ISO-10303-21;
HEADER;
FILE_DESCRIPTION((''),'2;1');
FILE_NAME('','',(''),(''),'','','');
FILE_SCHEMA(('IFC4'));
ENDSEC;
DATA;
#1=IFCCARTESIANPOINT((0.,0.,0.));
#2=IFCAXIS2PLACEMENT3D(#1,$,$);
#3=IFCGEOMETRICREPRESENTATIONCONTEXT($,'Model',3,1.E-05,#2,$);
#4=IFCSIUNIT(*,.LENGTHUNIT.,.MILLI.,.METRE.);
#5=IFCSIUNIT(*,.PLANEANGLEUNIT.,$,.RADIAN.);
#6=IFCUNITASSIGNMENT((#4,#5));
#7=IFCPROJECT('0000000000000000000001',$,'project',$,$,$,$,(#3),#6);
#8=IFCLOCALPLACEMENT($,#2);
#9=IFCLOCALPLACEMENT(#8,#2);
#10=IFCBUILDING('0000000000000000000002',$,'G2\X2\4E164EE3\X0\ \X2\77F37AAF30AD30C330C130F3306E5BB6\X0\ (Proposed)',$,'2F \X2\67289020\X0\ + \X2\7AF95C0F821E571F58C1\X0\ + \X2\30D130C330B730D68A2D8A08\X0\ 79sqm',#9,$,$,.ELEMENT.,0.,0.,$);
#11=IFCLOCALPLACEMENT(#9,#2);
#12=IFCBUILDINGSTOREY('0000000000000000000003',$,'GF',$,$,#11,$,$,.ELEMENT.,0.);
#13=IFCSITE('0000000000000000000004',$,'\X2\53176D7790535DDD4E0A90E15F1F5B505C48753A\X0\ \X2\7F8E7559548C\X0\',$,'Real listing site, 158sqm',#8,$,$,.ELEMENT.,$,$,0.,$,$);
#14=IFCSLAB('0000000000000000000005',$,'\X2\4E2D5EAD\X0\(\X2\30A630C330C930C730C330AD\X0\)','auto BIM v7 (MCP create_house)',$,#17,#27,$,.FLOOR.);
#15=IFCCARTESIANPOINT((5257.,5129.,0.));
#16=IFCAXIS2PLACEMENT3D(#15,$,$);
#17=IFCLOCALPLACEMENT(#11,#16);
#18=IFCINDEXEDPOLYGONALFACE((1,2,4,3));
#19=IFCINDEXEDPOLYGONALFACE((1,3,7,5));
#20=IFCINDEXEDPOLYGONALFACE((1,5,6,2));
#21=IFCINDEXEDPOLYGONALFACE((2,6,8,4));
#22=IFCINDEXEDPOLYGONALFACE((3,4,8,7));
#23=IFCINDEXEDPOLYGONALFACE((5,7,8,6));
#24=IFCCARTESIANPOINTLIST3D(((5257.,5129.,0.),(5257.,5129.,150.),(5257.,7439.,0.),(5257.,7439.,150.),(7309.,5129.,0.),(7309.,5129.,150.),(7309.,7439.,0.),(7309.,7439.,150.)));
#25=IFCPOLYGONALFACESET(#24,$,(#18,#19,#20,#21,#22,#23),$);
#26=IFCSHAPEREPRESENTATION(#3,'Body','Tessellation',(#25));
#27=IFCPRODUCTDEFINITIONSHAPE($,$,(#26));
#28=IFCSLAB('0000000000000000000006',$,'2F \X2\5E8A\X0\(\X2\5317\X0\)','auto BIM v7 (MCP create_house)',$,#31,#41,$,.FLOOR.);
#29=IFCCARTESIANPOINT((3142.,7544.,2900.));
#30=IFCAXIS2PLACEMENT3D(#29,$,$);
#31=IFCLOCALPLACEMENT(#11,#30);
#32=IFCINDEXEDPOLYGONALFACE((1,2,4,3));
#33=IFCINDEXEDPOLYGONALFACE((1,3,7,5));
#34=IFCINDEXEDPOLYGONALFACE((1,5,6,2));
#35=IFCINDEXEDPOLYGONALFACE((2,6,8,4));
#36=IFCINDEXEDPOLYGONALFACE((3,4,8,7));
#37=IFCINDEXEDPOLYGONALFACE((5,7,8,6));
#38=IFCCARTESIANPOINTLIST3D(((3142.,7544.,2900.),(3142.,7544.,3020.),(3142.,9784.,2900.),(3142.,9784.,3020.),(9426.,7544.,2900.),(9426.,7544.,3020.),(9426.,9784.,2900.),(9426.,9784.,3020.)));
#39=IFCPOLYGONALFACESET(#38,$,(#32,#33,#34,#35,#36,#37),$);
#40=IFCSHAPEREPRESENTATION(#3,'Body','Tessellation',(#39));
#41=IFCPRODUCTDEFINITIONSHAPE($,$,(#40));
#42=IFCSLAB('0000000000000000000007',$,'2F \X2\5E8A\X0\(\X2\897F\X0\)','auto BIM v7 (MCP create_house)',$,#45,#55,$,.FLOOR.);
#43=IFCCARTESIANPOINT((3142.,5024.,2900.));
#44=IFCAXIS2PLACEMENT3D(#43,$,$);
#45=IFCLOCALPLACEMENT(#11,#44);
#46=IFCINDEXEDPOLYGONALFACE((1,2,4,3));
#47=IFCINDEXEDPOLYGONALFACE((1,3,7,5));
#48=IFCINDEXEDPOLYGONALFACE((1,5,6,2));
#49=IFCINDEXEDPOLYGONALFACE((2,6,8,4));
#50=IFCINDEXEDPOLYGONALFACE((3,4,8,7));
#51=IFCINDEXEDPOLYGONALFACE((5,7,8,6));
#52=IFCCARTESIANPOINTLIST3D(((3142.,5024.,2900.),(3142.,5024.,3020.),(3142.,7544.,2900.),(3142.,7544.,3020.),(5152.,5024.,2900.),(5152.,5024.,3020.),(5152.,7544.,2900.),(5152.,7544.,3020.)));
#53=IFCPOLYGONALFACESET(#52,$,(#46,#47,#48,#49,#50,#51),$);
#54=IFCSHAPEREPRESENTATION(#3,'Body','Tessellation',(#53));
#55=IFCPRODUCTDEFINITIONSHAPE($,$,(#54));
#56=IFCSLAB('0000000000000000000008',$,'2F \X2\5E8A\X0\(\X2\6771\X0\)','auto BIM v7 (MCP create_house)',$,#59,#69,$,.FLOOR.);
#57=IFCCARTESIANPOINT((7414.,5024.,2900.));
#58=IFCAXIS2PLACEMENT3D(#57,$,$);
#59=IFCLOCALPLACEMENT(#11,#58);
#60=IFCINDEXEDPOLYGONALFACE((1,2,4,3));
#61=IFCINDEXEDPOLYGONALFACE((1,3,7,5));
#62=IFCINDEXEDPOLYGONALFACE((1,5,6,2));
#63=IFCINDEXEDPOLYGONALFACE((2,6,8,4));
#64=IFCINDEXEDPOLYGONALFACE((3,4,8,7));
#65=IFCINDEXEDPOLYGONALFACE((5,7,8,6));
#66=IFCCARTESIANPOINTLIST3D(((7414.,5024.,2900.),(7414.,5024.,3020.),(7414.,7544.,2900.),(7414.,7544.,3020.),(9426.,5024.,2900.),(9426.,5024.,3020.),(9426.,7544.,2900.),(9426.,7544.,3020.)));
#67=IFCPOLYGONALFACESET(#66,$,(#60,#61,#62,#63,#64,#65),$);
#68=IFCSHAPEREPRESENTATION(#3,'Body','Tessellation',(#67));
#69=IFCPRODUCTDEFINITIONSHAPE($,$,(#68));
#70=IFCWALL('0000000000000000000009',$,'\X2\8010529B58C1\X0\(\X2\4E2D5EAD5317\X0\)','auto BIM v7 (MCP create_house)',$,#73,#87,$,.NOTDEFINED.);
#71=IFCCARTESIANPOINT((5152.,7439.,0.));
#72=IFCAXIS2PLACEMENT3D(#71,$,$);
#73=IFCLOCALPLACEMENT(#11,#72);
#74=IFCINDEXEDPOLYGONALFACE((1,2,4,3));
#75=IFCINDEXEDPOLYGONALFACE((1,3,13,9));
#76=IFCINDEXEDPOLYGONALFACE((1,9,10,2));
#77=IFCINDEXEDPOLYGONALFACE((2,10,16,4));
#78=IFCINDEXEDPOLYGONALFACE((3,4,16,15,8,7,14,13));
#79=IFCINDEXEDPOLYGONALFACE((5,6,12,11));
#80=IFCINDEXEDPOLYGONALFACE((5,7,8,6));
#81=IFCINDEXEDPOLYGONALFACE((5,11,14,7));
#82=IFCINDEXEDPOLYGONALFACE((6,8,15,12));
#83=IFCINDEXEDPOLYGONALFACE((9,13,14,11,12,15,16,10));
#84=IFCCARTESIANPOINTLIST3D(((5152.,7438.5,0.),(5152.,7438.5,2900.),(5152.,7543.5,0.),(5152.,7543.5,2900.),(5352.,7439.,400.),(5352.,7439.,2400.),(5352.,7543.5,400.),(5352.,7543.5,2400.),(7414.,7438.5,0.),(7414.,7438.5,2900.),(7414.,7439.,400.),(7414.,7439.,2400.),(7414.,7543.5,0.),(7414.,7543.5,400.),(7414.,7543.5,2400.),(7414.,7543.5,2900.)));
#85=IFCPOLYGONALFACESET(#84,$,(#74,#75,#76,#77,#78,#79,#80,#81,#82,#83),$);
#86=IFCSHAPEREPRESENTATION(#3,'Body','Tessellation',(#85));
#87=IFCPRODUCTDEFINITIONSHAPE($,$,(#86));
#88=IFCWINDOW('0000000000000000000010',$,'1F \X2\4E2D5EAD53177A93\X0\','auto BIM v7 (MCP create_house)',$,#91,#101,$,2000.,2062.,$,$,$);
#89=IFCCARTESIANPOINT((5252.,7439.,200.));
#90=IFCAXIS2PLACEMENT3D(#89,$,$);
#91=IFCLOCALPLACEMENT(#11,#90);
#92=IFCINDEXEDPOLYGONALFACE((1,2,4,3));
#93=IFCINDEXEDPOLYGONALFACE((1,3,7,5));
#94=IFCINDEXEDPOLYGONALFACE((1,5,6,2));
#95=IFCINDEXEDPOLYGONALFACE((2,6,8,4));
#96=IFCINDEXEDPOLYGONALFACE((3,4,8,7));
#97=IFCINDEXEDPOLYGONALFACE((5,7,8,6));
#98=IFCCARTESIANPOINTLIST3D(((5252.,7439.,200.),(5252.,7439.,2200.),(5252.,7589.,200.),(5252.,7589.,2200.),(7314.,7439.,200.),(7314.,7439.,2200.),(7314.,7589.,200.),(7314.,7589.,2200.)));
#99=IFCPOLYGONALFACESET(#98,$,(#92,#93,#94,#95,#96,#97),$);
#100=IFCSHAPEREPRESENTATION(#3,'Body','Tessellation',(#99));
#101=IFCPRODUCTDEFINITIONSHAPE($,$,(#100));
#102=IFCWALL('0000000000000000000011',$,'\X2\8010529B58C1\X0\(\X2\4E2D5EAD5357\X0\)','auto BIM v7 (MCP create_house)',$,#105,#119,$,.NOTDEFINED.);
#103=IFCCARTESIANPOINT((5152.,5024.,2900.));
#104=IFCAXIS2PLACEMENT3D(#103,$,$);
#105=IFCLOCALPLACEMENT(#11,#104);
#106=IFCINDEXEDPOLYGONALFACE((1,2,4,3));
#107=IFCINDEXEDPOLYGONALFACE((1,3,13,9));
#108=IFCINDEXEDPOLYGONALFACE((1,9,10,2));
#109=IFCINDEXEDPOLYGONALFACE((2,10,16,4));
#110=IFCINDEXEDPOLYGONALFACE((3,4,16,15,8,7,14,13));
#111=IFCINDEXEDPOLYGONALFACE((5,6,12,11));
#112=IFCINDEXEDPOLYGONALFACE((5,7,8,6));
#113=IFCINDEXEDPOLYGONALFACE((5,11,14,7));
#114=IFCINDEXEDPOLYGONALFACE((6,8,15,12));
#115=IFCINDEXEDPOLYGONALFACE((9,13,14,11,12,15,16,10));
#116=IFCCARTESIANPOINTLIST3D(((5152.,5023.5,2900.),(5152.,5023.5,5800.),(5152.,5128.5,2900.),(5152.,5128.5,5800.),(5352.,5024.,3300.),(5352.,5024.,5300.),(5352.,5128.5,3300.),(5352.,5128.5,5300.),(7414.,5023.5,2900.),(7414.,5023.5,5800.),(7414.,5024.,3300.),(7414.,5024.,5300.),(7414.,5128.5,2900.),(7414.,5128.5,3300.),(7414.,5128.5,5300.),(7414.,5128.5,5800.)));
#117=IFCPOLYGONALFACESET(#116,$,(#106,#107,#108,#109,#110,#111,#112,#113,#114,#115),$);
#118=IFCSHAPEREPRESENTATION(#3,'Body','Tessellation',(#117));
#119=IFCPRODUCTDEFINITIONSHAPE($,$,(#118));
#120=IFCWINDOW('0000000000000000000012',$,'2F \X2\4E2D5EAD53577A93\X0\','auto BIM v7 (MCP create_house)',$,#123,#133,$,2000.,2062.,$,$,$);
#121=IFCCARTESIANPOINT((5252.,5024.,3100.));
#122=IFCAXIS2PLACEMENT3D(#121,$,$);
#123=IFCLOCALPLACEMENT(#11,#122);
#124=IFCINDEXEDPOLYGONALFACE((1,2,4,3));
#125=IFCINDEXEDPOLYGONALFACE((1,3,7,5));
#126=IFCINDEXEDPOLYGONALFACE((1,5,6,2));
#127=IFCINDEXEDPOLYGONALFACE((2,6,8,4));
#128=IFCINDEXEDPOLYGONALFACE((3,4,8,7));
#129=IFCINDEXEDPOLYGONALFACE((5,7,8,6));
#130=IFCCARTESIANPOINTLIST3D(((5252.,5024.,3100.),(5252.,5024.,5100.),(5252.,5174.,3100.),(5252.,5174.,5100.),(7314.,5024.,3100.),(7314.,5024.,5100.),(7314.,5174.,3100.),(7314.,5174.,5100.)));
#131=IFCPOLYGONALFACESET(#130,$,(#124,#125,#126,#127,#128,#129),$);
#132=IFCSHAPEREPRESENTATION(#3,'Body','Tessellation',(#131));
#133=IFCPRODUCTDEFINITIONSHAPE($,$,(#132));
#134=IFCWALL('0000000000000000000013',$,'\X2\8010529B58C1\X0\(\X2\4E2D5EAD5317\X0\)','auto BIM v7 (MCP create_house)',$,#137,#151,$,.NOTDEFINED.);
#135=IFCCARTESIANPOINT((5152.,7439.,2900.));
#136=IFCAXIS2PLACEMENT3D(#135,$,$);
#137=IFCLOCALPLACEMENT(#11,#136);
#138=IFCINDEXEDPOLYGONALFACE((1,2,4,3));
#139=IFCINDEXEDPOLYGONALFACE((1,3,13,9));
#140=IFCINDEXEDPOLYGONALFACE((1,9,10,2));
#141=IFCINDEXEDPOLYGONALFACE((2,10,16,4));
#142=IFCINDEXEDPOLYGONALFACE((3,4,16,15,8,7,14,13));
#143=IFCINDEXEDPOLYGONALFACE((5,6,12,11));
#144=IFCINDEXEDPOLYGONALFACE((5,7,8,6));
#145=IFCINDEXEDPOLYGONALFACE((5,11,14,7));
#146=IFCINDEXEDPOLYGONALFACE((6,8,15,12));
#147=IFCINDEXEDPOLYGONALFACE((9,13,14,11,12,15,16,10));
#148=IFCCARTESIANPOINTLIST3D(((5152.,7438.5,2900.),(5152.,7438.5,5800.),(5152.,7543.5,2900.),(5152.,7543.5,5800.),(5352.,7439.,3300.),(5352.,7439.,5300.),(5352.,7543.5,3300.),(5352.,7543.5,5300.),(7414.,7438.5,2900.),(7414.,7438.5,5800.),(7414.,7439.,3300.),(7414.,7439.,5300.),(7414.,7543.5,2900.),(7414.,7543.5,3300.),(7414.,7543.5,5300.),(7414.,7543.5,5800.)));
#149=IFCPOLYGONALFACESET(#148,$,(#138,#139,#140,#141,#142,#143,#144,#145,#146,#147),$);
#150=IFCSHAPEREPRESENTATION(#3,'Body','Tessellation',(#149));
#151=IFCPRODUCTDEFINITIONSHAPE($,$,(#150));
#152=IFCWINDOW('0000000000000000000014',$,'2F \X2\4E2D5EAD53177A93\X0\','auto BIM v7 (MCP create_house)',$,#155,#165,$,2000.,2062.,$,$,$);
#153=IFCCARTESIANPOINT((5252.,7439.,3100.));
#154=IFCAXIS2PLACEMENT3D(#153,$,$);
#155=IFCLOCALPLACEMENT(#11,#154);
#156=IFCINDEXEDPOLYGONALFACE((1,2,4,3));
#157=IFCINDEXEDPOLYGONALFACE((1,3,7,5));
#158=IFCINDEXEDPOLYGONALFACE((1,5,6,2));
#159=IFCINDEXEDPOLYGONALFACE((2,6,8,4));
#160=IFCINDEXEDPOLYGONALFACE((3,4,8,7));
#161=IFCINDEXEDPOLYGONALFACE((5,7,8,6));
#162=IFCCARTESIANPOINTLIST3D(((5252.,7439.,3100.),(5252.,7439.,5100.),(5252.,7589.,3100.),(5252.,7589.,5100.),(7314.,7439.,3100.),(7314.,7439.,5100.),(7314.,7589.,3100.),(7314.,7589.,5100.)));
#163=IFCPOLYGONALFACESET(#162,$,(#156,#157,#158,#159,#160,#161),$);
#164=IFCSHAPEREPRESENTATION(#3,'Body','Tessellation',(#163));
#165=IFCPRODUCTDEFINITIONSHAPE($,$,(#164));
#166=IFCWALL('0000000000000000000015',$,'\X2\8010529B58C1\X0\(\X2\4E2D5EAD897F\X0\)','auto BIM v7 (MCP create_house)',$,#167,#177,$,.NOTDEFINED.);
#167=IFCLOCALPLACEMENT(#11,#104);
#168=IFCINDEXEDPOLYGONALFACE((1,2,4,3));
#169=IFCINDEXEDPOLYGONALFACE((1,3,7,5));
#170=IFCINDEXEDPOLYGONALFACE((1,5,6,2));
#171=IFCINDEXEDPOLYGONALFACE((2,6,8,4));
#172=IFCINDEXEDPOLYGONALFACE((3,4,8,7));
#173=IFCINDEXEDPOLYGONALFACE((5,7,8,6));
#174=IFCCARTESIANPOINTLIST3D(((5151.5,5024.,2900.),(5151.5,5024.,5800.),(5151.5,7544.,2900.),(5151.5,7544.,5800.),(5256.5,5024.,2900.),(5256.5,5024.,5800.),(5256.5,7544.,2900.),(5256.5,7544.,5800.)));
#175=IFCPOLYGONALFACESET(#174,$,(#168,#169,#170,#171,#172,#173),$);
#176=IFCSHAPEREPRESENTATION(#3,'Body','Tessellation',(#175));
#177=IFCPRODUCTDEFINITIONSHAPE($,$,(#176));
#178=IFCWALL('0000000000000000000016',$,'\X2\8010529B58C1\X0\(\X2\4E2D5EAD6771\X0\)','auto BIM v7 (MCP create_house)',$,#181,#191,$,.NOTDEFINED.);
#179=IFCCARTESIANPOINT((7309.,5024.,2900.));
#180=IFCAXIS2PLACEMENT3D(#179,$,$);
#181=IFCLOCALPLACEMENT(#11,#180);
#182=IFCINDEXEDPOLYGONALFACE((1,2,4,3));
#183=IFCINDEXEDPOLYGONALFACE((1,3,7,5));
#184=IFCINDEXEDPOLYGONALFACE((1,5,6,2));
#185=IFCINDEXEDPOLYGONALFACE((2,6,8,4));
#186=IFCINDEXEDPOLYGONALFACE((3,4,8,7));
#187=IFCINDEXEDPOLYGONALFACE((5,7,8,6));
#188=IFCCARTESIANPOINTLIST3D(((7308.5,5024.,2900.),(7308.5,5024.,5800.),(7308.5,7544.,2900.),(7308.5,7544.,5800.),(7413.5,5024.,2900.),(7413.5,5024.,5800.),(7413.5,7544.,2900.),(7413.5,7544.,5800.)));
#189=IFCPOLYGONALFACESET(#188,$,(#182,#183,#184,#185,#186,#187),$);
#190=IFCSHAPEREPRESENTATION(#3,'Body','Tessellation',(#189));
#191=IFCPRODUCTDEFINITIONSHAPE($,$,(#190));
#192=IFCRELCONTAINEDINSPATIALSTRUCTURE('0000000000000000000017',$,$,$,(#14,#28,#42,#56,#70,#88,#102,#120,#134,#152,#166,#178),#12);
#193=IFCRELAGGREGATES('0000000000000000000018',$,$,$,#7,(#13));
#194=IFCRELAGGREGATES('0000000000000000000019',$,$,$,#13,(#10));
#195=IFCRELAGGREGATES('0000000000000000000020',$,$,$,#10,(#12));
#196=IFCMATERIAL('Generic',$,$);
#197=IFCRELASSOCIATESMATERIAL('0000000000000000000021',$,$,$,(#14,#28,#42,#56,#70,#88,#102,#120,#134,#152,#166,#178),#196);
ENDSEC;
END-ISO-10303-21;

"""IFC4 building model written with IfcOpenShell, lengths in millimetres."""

from ifc_helpers import new_model, si_unit, frame, frame_2d, origin, place, context, project, spatial, rectangle, extrude, material, element, fill, save


model = new_model("IFC4")

# Units and contexts
model_context = context("Model", 3, precision=1e-05, world=origin())
ifc_project = project(units=[si_unit("LENGTHUNIT", "METRE", prefix="MILLI"), si_unit("PLANEANGLEUNIT", "RADIAN")], contexts=[model_context])

# Site, building, storey
site_placement = place(None, origin())
site = spatial("IfcSite", under=ifc_project, at=site_placement, Name="北海道川上郡弟子屈町 美留和", ObjectType="Real listing site, 158sqm", CompositionType="ELEMENT", RefElevation=0.0)
building_placement = place(site_placement, origin())
building = spatial("IfcBuilding", under=site, at=building_placement, Name="G2世代 石窯キッチンの家 (Proposed)", ObjectType="2F 木造 + 竹小舞土壁 + パッシブ設計 79sqm", CompositionType="ELEMENT", ElevationOfRefHeight=0.0, ElevationOfTerrain=0.0)
storey_placement = place(building_placement, origin())
storey = spatial("IfcBuildingStorey", under=building, at=storey_placement, Name="GF", CompositionType="ELEMENT", Elevation=0.0)

# Slabs
ifc_material = material(Name="Generic")
slab_1_placement = place(storey_placement, frame((5257.0, 5129.0, 0.0)))
element("IfcSlab", 1, at=slab_1_placement, inside=storey, material=ifc_material, Name="中庭(ウッドデッキ)", Description="auto BIM v7 (MCP create_house)", PredefinedType="FLOOR", context=model_context, shape_type="SweptSolid", body=[
    extrude(rectangle(XDim=2052.0, YDim=2310.0, at=frame_2d((1026.0, 1155.0))), frame((5257.0, 5129.0, 0.0)), (0.0, 0.0, 1.0), 150.0),
])
slab_2_placement = place(storey_placement, frame((3142.0, 7544.0, 2900.0)))
element("IfcSlab", 2, at=slab_2_placement, inside=storey, material=ifc_material, Name="2F 床(北)", Description="auto BIM v7 (MCP create_house)", PredefinedType="FLOOR", context=model_context, shape_type="SweptSolid", body=[
    extrude(rectangle(XDim=6284.0, YDim=2240.0, at=frame_2d((3142.0, 1120.0))), frame((3142.0, 7544.0, 2900.0)), (0.0, 0.0, 1.0), 120.0),
])
slab_3_placement = place(storey_placement, frame((3142.0, 5024.0, 2900.0)))
element("IfcSlab", 3, at=slab_3_placement, inside=storey, material=ifc_material, Name="2F 床(西)", Description="auto BIM v7 (MCP create_house)", PredefinedType="FLOOR", context=model_context, shape_type="SweptSolid", body=[
    extrude(rectangle(XDim=2010.0, YDim=2520.0, at=frame_2d((1005.0, 1260.0))), frame((3142.0, 5024.0, 2900.0)), (0.0, 0.0, 1.0), 120.0),
])
slab_4_placement = place(storey_placement, frame((7414.0, 5024.0, 2900.0)))
element("IfcSlab", 4, at=slab_4_placement, inside=storey, material=ifc_material, Name="2F 床(東)", Description="auto BIM v7 (MCP create_house)", PredefinedType="FLOOR", context=model_context, shape_type="SweptSolid", body=[
    extrude(rectangle(XDim=2012.0, YDim=2520.0, at=frame_2d((1006.0, 1260.0))), frame((7414.0, 5024.0, 2900.0)), (0.0, 0.0, 1.0), 120.0),
])

# Wall, opening, window
wall_1_placement = place(storey_placement, frame((5152.0, 7439.0, 0.0)))
wall_1 = element("IfcWall", 5, at=wall_1_placement, inside=storey, material=ifc_material, Name="耐力壁(中庭北)", Description="auto BIM v7 (MCP create_house)", PredefinedType="NOTDEFINED", context=model_context, shape_type="SweptSolid", body=[
    extrude(rectangle(XDim=2262.0, YDim=105.0, at=frame_2d((1131.0, 52.0))), frame((5152.0, 7439.0, 0.0)), (0.0, 0.0, 1.0), 2900.0),
])
opening_1_placement = place(storey_placement, frame((5252.0, 7439.0, 200.0)))
opening_1 = element("IfcOpeningElement", 6, at=opening_1_placement, cuts=wall_1, PredefinedType="NOTDEFINED", context=model_context, shape_type="SweptSolid", body=[
    extrude(rectangle(XDim=2062.0, YDim=150.0, at=frame_2d((1031.0, 75.0))), frame((5252.0, 7439.0, 200.0)), (0.0, 0.0, 1.0), 2000.0),
])
window_1_placement = place(storey_placement, frame((5252.0, 7439.0, 200.0)))
window_1 = element("IfcWindow", 7, at=window_1_placement, inside=storey, material=ifc_material, Name="1F 中庭北窓", Description="auto BIM v7 (MCP create_house)", OverallHeight=2000.0, OverallWidth=2062.0, context=model_context, shape_type="SweptSolid", body=[
    extrude(rectangle(XDim=2062.0, YDim=150.0, at=frame_2d((1031.0, 75.0))), frame((5252.0, 7439.0, 200.0)), (0.0, 0.0, 1.0), 2000.0),
])
fill(opening_1, window_1)

# Walls, openings, windows
wall_2_placement = place(storey_placement, frame((5152.0, 5024.0, 2900.0)))
wall_2 = element("IfcWall", 8, at=wall_2_placement, inside=storey, material=ifc_material, Name="耐力壁(中庭南)", Description="auto BIM v7 (MCP create_house)", PredefinedType="NOTDEFINED", context=model_context, shape_type="SweptSolid", body=[
    extrude(rectangle(XDim=2262.0, YDim=105.0, at=frame_2d((1131.0, 52.0))), frame((5152.0, 5024.0, 2900.0)), (0.0, 0.0, 1.0), 2900.0),
])
opening_2_placement = place(storey_placement, frame((5252.0, 5024.0, 3100.0)))
opening_2 = element("IfcOpeningElement", 9, at=opening_2_placement, cuts=wall_2, PredefinedType="NOTDEFINED", context=model_context, shape_type="SweptSolid", body=[
    extrude(rectangle(XDim=2062.0, YDim=150.0, at=frame_2d((1031.0, 75.0))), frame((5252.0, 5024.0, 3100.0)), (0.0, 0.0, 1.0), 2000.0),
])
window_2_placement = place(storey_placement, frame((5252.0, 5024.0, 3100.0)))
window_2 = element("IfcWindow", 10, at=window_2_placement, inside=storey, material=ifc_material, Name="2F 中庭南窓", Description="auto BIM v7 (MCP create_house)", OverallHeight=2000.0, OverallWidth=2062.0, context=model_context, shape_type="SweptSolid", body=[
    extrude(rectangle(XDim=2062.0, YDim=150.0, at=frame_2d((1031.0, 75.0))), frame((5252.0, 5024.0, 3100.0)), (0.0, 0.0, 1.0), 2000.0),
])
fill(opening_2, window_2)
wall_3_placement = place(storey_placement, frame((5152.0, 7439.0, 2900.0)))
wall_3 = element("IfcWall", 11, at=wall_3_placement, inside=storey, material=ifc_material, Name="耐力壁(中庭北)", Description="auto BIM v7 (MCP create_house)", PredefinedType="NOTDEFINED", context=model_context, shape_type="SweptSolid", body=[
    extrude(rectangle(XDim=2262.0, YDim=105.0, at=frame_2d((1131.0, 52.0))), frame((5152.0, 7439.0, 2900.0)), (0.0, 0.0, 1.0), 2900.0),
])
opening_3_placement = place(storey_placement, frame((5252.0, 7439.0, 3100.0)))
opening_3 = element("IfcOpeningElement", 12, at=opening_3_placement, cuts=wall_3, PredefinedType="NOTDEFINED", context=model_context, shape_type="SweptSolid", body=[
    extrude(rectangle(XDim=2062.0, YDim=150.0, at=frame_2d((1031.0, 75.0))), frame((5252.0, 7439.0, 3100.0)), (0.0, 0.0, 1.0), 2000.0),
])
window_3_placement = place(storey_placement, frame((5252.0, 7439.0, 3100.0)))
window_3 = element("IfcWindow", 13, at=window_3_placement, inside=storey, material=ifc_material, Name="2F 中庭北窓", Description="auto BIM v7 (MCP create_house)", OverallHeight=2000.0, OverallWidth=2062.0, context=model_context, shape_type="SweptSolid", body=[
    extrude(rectangle(XDim=2062.0, YDim=150.0, at=frame_2d((1031.0, 75.0))), frame((5252.0, 7439.0, 3100.0)), (0.0, 0.0, 1.0), 2000.0),
])
fill(opening_3, window_3)

# Walls
wall_4_placement = place(storey_placement, frame((5152.0, 5024.0, 2900.0)))
element("IfcWall", 14, at=wall_4_placement, inside=storey, material=ifc_material, Name="耐力壁(中庭西)", Description="auto BIM v7 (MCP create_house)", PredefinedType="NOTDEFINED", context=model_context, shape_type="SweptSolid", body=[
    extrude(rectangle(XDim=105.0, YDim=2520.0, at=frame_2d((52.0, 1260.0))), frame((5152.0, 5024.0, 2900.0)), (0.0, 0.0, 1.0), 2900.0),
])
wall_5_placement = place(storey_placement, frame((7309.0, 5024.0, 2900.0)))
element("IfcWall", 15, at=wall_5_placement, inside=storey, material=ifc_material, Name="耐力壁(中庭東)", Description="auto BIM v7 (MCP create_house)", PredefinedType="NOTDEFINED", context=model_context, shape_type="SweptSolid", body=[
    extrude(rectangle(XDim=105.0, YDim=2520.0, at=frame_2d((52.0, 1260.0))), frame((7309.0, 5024.0, 2900.0)), (0.0, 0.0, 1.0), 2900.0),
])

save(model, "model.ifc")
